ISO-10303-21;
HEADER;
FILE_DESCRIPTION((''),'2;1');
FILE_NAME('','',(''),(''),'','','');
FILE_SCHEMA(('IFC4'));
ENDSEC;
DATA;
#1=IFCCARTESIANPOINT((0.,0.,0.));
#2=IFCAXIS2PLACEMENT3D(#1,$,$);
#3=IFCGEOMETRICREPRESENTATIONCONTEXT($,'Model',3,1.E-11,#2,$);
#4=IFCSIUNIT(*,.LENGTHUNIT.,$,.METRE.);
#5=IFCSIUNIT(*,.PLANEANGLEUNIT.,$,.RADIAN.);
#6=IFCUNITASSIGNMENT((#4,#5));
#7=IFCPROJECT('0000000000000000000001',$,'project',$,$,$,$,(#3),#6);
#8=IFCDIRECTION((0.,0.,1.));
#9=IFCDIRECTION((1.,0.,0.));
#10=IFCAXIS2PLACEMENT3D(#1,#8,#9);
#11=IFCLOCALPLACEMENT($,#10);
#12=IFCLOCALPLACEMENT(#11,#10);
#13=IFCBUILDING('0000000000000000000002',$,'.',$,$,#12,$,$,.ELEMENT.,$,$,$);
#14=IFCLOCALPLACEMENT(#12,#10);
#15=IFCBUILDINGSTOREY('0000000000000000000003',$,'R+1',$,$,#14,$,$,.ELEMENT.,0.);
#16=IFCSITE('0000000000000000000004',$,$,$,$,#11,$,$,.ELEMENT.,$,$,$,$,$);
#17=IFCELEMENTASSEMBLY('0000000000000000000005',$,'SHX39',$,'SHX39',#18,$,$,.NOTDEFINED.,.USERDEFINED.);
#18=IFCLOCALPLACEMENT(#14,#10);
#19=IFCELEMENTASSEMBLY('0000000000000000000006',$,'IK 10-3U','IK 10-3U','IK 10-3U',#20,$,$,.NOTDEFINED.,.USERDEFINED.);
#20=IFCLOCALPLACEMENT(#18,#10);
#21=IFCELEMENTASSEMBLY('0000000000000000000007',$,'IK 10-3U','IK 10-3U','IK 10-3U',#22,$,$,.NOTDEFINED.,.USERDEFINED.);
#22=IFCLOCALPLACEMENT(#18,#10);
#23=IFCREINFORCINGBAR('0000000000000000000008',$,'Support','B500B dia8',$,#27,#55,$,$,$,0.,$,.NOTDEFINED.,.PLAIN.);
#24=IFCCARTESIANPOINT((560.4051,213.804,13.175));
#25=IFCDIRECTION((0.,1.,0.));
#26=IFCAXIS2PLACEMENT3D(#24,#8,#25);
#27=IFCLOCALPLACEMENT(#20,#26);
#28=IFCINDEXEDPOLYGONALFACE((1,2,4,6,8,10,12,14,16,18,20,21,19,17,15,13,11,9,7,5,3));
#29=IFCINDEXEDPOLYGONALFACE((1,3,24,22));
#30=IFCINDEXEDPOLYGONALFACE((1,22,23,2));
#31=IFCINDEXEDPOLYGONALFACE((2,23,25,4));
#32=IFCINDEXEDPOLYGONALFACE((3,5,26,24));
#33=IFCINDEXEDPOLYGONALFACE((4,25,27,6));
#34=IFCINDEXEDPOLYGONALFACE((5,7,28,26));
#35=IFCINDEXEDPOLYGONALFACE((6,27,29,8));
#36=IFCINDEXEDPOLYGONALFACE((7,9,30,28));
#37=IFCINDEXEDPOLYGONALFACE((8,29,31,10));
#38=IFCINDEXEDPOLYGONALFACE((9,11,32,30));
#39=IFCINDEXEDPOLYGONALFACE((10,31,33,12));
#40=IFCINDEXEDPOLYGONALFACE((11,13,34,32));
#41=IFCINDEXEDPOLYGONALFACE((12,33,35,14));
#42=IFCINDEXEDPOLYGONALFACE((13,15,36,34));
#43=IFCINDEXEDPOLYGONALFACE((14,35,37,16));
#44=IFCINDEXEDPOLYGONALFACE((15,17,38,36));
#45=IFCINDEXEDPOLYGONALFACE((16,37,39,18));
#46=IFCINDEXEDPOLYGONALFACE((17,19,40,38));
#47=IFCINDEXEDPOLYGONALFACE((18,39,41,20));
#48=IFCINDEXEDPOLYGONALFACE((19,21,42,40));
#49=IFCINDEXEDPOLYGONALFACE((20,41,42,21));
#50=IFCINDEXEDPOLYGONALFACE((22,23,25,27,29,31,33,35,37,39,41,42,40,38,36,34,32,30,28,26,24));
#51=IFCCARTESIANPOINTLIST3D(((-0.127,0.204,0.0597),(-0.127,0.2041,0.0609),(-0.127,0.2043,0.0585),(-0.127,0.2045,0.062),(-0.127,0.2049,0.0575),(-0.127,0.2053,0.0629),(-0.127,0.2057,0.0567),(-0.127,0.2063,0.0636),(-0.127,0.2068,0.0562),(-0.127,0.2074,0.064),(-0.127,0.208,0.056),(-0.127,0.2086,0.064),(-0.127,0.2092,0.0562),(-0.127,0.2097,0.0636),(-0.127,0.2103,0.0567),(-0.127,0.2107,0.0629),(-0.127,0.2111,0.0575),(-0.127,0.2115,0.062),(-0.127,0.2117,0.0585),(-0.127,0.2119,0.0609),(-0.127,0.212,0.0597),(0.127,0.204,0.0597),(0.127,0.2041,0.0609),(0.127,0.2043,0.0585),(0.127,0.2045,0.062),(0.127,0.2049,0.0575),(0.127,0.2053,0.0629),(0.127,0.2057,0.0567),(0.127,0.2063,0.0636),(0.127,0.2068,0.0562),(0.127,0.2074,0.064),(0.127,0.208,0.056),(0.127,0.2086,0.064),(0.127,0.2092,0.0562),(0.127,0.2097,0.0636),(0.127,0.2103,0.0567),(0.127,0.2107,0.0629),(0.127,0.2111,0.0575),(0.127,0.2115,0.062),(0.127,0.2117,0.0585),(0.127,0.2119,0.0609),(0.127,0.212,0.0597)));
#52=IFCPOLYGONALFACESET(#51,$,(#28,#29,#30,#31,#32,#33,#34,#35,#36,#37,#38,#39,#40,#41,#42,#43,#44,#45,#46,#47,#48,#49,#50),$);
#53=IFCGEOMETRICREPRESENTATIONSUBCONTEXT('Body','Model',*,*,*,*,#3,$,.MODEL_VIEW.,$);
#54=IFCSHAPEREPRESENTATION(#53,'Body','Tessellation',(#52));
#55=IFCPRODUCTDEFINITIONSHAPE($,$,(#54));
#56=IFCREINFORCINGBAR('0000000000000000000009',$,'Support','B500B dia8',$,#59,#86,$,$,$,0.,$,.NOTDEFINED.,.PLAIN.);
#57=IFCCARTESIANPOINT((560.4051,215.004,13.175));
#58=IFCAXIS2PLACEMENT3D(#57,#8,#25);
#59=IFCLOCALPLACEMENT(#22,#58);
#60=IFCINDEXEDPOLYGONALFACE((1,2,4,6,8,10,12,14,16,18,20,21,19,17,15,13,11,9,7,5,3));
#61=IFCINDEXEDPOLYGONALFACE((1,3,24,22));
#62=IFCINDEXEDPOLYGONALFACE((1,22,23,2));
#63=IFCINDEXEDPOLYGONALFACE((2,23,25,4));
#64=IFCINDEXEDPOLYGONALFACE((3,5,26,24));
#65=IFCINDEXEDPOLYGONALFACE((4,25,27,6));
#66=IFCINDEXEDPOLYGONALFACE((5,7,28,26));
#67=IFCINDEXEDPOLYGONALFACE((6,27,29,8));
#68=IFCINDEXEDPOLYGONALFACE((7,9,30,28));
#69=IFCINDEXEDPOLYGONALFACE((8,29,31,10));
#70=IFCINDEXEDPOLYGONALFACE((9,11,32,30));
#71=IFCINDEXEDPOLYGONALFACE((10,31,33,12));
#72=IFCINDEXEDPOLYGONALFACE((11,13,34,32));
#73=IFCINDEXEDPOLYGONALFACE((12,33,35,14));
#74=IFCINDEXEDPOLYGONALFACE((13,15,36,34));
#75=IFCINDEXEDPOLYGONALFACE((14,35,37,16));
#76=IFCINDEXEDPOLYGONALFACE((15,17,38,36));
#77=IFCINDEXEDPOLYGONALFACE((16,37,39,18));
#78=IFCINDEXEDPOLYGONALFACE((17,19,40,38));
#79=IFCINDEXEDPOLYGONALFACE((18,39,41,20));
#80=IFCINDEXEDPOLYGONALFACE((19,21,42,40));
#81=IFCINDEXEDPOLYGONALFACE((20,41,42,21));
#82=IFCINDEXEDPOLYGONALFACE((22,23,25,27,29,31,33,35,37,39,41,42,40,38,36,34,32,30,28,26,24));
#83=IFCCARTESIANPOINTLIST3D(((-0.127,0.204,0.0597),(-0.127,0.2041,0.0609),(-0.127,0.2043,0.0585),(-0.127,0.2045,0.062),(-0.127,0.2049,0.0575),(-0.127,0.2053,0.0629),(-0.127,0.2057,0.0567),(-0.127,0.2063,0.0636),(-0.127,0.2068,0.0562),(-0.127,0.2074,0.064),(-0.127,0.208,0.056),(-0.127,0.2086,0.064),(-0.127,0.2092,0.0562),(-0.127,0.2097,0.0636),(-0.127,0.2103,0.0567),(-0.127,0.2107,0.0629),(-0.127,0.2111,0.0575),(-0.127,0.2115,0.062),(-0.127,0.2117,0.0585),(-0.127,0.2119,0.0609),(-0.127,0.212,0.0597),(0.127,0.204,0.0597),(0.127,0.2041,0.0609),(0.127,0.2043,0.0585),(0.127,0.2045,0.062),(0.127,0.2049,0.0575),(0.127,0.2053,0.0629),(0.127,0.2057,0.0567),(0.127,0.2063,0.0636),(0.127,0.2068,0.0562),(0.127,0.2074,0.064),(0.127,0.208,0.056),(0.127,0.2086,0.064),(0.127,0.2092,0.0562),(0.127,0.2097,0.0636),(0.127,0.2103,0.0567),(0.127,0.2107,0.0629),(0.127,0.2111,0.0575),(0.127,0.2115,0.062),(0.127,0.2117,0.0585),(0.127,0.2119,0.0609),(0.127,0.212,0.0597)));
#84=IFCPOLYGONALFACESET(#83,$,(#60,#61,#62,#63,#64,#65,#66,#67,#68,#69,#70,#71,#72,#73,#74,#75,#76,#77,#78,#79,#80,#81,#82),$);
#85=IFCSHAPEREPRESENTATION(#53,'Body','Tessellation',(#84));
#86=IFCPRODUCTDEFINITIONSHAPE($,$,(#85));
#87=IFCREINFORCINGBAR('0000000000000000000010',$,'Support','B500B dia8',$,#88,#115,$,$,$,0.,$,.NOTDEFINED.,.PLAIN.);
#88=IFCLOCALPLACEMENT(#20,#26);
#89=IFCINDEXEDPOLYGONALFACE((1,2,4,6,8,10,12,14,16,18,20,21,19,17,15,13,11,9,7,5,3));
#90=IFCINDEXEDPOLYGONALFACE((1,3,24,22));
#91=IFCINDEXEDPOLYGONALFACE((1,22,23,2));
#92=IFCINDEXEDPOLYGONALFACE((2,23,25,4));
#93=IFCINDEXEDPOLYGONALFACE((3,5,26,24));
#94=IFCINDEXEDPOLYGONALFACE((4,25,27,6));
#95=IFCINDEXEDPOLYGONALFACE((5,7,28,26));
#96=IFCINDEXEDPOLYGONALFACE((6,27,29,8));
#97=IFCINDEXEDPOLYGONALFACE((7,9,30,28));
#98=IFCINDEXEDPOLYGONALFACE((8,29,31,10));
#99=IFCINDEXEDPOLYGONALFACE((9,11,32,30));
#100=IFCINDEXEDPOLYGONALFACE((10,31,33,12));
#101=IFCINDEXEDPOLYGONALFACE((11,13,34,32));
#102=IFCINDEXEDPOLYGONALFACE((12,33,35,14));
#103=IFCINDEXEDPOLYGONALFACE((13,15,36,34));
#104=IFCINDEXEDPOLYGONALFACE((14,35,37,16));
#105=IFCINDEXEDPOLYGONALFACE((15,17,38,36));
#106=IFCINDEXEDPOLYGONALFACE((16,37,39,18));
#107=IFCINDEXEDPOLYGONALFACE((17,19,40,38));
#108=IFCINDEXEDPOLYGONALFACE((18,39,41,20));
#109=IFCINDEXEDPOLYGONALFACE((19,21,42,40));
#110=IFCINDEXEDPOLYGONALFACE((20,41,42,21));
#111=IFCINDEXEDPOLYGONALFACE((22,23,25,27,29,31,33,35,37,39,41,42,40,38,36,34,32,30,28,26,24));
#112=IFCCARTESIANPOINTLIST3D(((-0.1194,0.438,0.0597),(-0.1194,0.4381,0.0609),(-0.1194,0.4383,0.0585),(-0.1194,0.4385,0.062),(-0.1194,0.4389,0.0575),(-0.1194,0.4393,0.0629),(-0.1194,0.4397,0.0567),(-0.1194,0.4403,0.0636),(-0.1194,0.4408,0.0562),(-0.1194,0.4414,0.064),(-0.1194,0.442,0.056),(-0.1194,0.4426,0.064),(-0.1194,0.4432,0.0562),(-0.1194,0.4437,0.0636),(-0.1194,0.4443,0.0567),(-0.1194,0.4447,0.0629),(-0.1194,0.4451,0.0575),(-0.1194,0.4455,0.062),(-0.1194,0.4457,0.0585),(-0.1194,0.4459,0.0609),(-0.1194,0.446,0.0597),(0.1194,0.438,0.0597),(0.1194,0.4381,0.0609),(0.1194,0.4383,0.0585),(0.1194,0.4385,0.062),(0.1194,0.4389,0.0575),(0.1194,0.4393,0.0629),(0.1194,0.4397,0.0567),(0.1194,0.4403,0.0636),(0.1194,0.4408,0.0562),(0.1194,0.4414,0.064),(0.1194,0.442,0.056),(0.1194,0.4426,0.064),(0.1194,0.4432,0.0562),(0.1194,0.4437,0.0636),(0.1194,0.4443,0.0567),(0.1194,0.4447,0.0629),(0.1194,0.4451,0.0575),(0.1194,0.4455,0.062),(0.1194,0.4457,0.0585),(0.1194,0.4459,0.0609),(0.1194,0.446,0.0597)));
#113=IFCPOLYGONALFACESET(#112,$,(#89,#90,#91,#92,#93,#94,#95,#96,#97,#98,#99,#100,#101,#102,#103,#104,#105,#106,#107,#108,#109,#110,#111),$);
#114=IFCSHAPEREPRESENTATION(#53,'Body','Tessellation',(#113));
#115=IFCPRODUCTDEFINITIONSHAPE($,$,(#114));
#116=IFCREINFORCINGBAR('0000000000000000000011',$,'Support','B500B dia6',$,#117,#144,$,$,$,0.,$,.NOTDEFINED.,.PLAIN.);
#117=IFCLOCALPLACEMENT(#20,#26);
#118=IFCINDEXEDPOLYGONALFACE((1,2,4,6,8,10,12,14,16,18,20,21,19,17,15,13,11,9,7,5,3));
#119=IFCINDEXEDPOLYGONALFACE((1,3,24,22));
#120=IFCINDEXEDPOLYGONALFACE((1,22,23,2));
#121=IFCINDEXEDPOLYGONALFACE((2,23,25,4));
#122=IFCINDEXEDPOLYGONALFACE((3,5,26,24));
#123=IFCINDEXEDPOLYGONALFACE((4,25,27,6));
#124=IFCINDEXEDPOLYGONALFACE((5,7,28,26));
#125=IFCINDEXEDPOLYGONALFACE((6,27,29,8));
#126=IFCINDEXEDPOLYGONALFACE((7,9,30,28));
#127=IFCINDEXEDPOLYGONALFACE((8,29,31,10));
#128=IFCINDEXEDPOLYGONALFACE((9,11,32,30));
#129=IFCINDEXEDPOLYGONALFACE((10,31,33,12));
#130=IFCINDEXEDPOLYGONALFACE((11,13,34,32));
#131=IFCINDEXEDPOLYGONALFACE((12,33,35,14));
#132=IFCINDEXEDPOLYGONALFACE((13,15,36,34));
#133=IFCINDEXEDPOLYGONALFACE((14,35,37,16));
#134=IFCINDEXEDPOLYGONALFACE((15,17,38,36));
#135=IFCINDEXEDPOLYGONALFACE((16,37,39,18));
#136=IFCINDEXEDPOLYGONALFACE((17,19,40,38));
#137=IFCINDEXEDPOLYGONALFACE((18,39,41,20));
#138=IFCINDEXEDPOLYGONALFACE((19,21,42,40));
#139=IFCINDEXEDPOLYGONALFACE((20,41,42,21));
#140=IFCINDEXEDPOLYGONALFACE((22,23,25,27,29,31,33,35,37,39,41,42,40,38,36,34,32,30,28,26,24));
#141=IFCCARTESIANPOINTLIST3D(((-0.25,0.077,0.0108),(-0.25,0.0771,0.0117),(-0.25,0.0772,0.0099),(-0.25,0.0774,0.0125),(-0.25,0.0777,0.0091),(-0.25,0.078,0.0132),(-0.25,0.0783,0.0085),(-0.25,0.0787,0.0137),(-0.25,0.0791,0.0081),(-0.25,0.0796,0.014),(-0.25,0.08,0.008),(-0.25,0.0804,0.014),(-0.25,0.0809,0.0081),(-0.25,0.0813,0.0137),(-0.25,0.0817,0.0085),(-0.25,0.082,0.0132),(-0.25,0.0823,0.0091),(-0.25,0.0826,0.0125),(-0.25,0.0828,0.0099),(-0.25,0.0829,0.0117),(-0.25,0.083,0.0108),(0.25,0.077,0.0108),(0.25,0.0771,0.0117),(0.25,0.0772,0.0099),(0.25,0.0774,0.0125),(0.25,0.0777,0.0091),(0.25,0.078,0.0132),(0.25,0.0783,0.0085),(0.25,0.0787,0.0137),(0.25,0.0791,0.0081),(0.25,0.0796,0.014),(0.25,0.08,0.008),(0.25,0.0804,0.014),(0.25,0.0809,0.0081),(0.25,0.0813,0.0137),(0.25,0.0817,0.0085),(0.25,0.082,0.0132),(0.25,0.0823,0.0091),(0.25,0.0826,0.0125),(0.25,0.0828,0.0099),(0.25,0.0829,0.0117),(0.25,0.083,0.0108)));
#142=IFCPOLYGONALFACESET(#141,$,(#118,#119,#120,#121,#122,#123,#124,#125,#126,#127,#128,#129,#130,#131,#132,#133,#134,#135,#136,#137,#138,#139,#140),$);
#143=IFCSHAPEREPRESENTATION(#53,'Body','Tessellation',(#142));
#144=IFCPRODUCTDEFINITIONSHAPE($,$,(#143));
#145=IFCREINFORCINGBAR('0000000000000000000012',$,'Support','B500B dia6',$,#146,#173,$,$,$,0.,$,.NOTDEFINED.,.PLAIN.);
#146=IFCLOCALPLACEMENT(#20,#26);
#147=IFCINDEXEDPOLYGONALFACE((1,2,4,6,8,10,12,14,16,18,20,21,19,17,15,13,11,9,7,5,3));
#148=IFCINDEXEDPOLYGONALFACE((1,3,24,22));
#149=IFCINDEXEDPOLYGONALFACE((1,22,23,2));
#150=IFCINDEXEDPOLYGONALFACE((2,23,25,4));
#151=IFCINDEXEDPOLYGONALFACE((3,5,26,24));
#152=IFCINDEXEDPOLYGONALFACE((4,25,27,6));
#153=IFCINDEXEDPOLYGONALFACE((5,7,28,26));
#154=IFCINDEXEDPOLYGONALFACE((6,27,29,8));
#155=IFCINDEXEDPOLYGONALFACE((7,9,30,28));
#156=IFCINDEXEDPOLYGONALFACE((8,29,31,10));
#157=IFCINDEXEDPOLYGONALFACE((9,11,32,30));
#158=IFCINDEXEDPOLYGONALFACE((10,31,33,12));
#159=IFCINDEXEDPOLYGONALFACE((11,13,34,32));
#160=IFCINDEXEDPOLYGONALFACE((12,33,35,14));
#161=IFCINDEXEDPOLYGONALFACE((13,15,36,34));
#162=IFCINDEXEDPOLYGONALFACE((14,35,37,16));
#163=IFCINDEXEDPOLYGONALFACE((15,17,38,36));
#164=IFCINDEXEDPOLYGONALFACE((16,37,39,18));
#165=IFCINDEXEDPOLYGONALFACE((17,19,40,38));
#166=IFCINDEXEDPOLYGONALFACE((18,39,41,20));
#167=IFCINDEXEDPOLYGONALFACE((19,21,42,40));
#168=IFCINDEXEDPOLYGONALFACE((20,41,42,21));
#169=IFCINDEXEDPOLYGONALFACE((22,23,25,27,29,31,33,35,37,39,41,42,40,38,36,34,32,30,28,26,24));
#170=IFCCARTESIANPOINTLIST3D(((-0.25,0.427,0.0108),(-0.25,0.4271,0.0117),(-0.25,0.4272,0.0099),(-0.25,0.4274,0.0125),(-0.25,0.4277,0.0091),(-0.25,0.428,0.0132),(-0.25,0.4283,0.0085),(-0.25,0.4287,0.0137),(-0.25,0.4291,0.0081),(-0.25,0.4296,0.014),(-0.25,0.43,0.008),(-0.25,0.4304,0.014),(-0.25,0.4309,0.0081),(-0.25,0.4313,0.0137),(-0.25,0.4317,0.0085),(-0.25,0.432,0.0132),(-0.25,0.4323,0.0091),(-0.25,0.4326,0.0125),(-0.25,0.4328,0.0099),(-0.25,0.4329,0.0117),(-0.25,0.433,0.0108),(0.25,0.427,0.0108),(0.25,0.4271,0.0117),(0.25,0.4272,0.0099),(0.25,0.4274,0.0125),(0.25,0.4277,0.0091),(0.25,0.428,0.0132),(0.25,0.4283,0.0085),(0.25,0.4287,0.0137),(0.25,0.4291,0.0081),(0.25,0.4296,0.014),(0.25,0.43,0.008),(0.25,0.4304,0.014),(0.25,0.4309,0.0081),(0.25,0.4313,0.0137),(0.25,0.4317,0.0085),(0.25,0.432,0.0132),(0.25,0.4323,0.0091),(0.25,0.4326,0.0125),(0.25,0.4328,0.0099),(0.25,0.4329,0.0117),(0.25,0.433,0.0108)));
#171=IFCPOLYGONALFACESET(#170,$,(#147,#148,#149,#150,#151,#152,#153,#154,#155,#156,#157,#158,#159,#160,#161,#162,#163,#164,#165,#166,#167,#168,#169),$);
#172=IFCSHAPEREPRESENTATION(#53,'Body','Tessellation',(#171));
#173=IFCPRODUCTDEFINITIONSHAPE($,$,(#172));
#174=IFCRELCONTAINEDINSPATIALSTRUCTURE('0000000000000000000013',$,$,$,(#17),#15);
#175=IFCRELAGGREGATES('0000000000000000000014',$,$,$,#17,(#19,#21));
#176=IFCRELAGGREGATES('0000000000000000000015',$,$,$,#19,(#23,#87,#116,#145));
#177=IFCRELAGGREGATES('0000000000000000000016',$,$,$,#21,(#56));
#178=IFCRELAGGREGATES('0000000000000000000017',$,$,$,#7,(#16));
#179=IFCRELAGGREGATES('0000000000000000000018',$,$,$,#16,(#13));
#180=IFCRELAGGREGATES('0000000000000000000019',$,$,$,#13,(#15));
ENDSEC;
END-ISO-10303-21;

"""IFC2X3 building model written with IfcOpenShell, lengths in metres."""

from ifc_helpers import new_model, entity, si_unit, frame, origin, origin_with_axes, place, context, subcontext, project, spatial, source, transform, mapped, element, aggregate, save


model = new_model("IFC2X3")

# Units and contexts
model_context = context("Model", 3, precision=1e-11, world=origin())
body_context = subcontext(model_context, "Body", "Model", "MODEL_VIEW")
ifc_project = project(units=[si_unit("LENGTHUNIT", "METRE"), si_unit("PLANEANGLEUNIT", "RADIAN")], contexts=[model_context])

# Site, building, storey
site_placement = place(None, origin_with_axes())
site = spatial("IfcSite", under=ifc_project, at=site_placement, CompositionType="ELEMENT")
building_placement = place(site_placement, origin_with_axes())
building = spatial("IfcBuilding", under=site, at=building_placement, Name=".", CompositionType="ELEMENT")
storey_placement = place(building_placement, origin_with_axes())
storey = spatial("IfcBuildingStorey", under=building, at=storey_placement, Name="R+1", CompositionType="ELEMENT", Elevation=0.0)

# Element assemblies, reinforcing bars
assembly_1_placement = place(storey_placement, origin_with_axes())
assembly_1 = element("IfcElementAssembly", 1, at=assembly_1_placement, inside=storey, Name="SHX39", ObjectType="SHX39", AssemblyPlace="NOTDEFINED", PredefinedType="USERDEFINED")
assembly_2_placement = place(assembly_1_placement, origin_with_axes())
assembly_2 = element("IfcElementAssembly", 2, at=assembly_2_placement, Name="IK 10-3U", Description="IK 10-3U", ObjectType="IK 10-3U", AssemblyPlace="NOTDEFINED", PredefinedType="USERDEFINED")
assembly_3_placement = place(assembly_1_placement, origin_with_axes())
assembly_3 = element("IfcElementAssembly", 3, at=assembly_3_placement, Name="IK 10-3U", Description="IK 10-3U", ObjectType="IK 10-3U", AssemblyPlace="NOTDEFINED", PredefinedType="USERDEFINED")
aggregate(assembly_1, [assembly_2, assembly_3])
shared_shape_1 = source(origin_with_axes(), body_context, "Body", "AdvancedSweptSolid", [
    entity("IfcSweptDiskSolid", entity("IfcPolyline", [entity("IfcCartesianPoint", [0.127, 0.208, 0.06]), entity("IfcCartesianPoint", [-0.127, 0.208, 0.06])]), 0.004, None, 0.0, 0.254),
])
reinforcing_bar_1_placement = place(assembly_2_placement, frame((560.4051, 213.804, 13.175), z_axis=(0.0, 0.0, 1.0), x_axis=(0.0, 1.0, 0.0)))
reinforcing_bar_1 = element("IfcReinforcingBar", 4, at=reinforcing_bar_1_placement, Name="Support", Description="B500B dia8", BarRole="NOTDEFINED", BarSurface="PLAIN", CrossSectionArea=0.0, context=body_context, shape_type="MappedRepresentation", body=[
    mapped(shared_shape_1, transform((0.0, 0.0, 0.0), scale=1.0)),
])
reinforcing_bar_2_placement = place(assembly_3_placement, frame((560.4051, 215.004, 13.175), z_axis=(0.0, 0.0, 1.0), x_axis=(0.0, 1.0, 0.0)))
reinforcing_bar_2 = element("IfcReinforcingBar", 5, at=reinforcing_bar_2_placement, Name="Support", Description="B500B dia8", BarRole="NOTDEFINED", BarSurface="PLAIN", CrossSectionArea=0.0, context=body_context, shape_type="MappedRepresentation", body=[
    mapped(shared_shape_1, transform((0.0, 0.0, 0.0), scale=1.0)),
])
shared_shape_2 = source(origin_with_axes(), body_context, "Body", "AdvancedSweptSolid", [
    entity("IfcSweptDiskSolid", entity("IfcPolyline", [entity("IfcCartesianPoint", [0.1194, 0.442, 0.06]), entity("IfcCartesianPoint", [-0.1194, 0.442, 0.06])]), 0.004, None, 0.0, 0.2388),
])
reinforcing_bar_3_placement = place(assembly_2_placement, frame((560.4051, 213.804, 13.175), z_axis=(0.0, 0.0, 1.0), x_axis=(0.0, 1.0, 0.0)))
reinforcing_bar_3 = element("IfcReinforcingBar", 6, at=reinforcing_bar_3_placement, Name="Support", Description="B500B dia8", BarRole="NOTDEFINED", BarSurface="PLAIN", CrossSectionArea=0.0, context=body_context, shape_type="MappedRepresentation", body=[
    mapped(shared_shape_2, transform((0.0, 0.0, 0.0), scale=1.0)),
])
shared_shape_3 = source(origin_with_axes(), body_context, "Body", "AdvancedSweptSolid", [
    entity("IfcSweptDiskSolid", entity("IfcPolyline", [entity("IfcCartesianPoint", [0.25, 0.08, 0.011]), entity("IfcCartesianPoint", [-0.25, 0.08, 0.011])]), 0.003, None, 0.0, 0.5),
])
reinforcing_bar_4_placement = place(assembly_2_placement, frame((560.4051, 213.804, 13.175), z_axis=(0.0, 0.0, 1.0), x_axis=(0.0, 1.0, 0.0)))
reinforcing_bar_4 = element("IfcReinforcingBar", 7, at=reinforcing_bar_4_placement, Name="Support", Description="B500B dia6", BarRole="NOTDEFINED", BarSurface="PLAIN", CrossSectionArea=0.0, context=body_context, shape_type="MappedRepresentation", body=[
    mapped(shared_shape_3, transform((0.0, 0.0, 0.0), scale=1.0)),
])
shared_shape_4 = source(origin_with_axes(), body_context, "Body", "AdvancedSweptSolid", [
    entity("IfcSweptDiskSolid", entity("IfcPolyline", [entity("IfcCartesianPoint", [0.25, 0.43, 0.011]), entity("IfcCartesianPoint", [-0.25, 0.43, 0.011])]), 0.003, None, 0.0, 0.5),
])
reinforcing_bar_5_placement = place(assembly_2_placement, frame((560.4051, 213.804, 13.175), z_axis=(0.0, 0.0, 1.0), x_axis=(0.0, 1.0, 0.0)))
reinforcing_bar_5 = element("IfcReinforcingBar", 8, at=reinforcing_bar_5_placement, Name="Support", Description="B500B dia6", BarRole="NOTDEFINED", BarSurface="PLAIN", CrossSectionArea=0.0, context=body_context, shape_type="MappedRepresentation", body=[
    mapped(shared_shape_4, transform((0.0, 0.0, 0.0), scale=1.0)),
])
aggregate(assembly_2, [reinforcing_bar_1, reinforcing_bar_3, reinforcing_bar_4, reinforcing_bar_5])
aggregate(assembly_3, [reinforcing_bar_2])

save(model, "model.ifc")
